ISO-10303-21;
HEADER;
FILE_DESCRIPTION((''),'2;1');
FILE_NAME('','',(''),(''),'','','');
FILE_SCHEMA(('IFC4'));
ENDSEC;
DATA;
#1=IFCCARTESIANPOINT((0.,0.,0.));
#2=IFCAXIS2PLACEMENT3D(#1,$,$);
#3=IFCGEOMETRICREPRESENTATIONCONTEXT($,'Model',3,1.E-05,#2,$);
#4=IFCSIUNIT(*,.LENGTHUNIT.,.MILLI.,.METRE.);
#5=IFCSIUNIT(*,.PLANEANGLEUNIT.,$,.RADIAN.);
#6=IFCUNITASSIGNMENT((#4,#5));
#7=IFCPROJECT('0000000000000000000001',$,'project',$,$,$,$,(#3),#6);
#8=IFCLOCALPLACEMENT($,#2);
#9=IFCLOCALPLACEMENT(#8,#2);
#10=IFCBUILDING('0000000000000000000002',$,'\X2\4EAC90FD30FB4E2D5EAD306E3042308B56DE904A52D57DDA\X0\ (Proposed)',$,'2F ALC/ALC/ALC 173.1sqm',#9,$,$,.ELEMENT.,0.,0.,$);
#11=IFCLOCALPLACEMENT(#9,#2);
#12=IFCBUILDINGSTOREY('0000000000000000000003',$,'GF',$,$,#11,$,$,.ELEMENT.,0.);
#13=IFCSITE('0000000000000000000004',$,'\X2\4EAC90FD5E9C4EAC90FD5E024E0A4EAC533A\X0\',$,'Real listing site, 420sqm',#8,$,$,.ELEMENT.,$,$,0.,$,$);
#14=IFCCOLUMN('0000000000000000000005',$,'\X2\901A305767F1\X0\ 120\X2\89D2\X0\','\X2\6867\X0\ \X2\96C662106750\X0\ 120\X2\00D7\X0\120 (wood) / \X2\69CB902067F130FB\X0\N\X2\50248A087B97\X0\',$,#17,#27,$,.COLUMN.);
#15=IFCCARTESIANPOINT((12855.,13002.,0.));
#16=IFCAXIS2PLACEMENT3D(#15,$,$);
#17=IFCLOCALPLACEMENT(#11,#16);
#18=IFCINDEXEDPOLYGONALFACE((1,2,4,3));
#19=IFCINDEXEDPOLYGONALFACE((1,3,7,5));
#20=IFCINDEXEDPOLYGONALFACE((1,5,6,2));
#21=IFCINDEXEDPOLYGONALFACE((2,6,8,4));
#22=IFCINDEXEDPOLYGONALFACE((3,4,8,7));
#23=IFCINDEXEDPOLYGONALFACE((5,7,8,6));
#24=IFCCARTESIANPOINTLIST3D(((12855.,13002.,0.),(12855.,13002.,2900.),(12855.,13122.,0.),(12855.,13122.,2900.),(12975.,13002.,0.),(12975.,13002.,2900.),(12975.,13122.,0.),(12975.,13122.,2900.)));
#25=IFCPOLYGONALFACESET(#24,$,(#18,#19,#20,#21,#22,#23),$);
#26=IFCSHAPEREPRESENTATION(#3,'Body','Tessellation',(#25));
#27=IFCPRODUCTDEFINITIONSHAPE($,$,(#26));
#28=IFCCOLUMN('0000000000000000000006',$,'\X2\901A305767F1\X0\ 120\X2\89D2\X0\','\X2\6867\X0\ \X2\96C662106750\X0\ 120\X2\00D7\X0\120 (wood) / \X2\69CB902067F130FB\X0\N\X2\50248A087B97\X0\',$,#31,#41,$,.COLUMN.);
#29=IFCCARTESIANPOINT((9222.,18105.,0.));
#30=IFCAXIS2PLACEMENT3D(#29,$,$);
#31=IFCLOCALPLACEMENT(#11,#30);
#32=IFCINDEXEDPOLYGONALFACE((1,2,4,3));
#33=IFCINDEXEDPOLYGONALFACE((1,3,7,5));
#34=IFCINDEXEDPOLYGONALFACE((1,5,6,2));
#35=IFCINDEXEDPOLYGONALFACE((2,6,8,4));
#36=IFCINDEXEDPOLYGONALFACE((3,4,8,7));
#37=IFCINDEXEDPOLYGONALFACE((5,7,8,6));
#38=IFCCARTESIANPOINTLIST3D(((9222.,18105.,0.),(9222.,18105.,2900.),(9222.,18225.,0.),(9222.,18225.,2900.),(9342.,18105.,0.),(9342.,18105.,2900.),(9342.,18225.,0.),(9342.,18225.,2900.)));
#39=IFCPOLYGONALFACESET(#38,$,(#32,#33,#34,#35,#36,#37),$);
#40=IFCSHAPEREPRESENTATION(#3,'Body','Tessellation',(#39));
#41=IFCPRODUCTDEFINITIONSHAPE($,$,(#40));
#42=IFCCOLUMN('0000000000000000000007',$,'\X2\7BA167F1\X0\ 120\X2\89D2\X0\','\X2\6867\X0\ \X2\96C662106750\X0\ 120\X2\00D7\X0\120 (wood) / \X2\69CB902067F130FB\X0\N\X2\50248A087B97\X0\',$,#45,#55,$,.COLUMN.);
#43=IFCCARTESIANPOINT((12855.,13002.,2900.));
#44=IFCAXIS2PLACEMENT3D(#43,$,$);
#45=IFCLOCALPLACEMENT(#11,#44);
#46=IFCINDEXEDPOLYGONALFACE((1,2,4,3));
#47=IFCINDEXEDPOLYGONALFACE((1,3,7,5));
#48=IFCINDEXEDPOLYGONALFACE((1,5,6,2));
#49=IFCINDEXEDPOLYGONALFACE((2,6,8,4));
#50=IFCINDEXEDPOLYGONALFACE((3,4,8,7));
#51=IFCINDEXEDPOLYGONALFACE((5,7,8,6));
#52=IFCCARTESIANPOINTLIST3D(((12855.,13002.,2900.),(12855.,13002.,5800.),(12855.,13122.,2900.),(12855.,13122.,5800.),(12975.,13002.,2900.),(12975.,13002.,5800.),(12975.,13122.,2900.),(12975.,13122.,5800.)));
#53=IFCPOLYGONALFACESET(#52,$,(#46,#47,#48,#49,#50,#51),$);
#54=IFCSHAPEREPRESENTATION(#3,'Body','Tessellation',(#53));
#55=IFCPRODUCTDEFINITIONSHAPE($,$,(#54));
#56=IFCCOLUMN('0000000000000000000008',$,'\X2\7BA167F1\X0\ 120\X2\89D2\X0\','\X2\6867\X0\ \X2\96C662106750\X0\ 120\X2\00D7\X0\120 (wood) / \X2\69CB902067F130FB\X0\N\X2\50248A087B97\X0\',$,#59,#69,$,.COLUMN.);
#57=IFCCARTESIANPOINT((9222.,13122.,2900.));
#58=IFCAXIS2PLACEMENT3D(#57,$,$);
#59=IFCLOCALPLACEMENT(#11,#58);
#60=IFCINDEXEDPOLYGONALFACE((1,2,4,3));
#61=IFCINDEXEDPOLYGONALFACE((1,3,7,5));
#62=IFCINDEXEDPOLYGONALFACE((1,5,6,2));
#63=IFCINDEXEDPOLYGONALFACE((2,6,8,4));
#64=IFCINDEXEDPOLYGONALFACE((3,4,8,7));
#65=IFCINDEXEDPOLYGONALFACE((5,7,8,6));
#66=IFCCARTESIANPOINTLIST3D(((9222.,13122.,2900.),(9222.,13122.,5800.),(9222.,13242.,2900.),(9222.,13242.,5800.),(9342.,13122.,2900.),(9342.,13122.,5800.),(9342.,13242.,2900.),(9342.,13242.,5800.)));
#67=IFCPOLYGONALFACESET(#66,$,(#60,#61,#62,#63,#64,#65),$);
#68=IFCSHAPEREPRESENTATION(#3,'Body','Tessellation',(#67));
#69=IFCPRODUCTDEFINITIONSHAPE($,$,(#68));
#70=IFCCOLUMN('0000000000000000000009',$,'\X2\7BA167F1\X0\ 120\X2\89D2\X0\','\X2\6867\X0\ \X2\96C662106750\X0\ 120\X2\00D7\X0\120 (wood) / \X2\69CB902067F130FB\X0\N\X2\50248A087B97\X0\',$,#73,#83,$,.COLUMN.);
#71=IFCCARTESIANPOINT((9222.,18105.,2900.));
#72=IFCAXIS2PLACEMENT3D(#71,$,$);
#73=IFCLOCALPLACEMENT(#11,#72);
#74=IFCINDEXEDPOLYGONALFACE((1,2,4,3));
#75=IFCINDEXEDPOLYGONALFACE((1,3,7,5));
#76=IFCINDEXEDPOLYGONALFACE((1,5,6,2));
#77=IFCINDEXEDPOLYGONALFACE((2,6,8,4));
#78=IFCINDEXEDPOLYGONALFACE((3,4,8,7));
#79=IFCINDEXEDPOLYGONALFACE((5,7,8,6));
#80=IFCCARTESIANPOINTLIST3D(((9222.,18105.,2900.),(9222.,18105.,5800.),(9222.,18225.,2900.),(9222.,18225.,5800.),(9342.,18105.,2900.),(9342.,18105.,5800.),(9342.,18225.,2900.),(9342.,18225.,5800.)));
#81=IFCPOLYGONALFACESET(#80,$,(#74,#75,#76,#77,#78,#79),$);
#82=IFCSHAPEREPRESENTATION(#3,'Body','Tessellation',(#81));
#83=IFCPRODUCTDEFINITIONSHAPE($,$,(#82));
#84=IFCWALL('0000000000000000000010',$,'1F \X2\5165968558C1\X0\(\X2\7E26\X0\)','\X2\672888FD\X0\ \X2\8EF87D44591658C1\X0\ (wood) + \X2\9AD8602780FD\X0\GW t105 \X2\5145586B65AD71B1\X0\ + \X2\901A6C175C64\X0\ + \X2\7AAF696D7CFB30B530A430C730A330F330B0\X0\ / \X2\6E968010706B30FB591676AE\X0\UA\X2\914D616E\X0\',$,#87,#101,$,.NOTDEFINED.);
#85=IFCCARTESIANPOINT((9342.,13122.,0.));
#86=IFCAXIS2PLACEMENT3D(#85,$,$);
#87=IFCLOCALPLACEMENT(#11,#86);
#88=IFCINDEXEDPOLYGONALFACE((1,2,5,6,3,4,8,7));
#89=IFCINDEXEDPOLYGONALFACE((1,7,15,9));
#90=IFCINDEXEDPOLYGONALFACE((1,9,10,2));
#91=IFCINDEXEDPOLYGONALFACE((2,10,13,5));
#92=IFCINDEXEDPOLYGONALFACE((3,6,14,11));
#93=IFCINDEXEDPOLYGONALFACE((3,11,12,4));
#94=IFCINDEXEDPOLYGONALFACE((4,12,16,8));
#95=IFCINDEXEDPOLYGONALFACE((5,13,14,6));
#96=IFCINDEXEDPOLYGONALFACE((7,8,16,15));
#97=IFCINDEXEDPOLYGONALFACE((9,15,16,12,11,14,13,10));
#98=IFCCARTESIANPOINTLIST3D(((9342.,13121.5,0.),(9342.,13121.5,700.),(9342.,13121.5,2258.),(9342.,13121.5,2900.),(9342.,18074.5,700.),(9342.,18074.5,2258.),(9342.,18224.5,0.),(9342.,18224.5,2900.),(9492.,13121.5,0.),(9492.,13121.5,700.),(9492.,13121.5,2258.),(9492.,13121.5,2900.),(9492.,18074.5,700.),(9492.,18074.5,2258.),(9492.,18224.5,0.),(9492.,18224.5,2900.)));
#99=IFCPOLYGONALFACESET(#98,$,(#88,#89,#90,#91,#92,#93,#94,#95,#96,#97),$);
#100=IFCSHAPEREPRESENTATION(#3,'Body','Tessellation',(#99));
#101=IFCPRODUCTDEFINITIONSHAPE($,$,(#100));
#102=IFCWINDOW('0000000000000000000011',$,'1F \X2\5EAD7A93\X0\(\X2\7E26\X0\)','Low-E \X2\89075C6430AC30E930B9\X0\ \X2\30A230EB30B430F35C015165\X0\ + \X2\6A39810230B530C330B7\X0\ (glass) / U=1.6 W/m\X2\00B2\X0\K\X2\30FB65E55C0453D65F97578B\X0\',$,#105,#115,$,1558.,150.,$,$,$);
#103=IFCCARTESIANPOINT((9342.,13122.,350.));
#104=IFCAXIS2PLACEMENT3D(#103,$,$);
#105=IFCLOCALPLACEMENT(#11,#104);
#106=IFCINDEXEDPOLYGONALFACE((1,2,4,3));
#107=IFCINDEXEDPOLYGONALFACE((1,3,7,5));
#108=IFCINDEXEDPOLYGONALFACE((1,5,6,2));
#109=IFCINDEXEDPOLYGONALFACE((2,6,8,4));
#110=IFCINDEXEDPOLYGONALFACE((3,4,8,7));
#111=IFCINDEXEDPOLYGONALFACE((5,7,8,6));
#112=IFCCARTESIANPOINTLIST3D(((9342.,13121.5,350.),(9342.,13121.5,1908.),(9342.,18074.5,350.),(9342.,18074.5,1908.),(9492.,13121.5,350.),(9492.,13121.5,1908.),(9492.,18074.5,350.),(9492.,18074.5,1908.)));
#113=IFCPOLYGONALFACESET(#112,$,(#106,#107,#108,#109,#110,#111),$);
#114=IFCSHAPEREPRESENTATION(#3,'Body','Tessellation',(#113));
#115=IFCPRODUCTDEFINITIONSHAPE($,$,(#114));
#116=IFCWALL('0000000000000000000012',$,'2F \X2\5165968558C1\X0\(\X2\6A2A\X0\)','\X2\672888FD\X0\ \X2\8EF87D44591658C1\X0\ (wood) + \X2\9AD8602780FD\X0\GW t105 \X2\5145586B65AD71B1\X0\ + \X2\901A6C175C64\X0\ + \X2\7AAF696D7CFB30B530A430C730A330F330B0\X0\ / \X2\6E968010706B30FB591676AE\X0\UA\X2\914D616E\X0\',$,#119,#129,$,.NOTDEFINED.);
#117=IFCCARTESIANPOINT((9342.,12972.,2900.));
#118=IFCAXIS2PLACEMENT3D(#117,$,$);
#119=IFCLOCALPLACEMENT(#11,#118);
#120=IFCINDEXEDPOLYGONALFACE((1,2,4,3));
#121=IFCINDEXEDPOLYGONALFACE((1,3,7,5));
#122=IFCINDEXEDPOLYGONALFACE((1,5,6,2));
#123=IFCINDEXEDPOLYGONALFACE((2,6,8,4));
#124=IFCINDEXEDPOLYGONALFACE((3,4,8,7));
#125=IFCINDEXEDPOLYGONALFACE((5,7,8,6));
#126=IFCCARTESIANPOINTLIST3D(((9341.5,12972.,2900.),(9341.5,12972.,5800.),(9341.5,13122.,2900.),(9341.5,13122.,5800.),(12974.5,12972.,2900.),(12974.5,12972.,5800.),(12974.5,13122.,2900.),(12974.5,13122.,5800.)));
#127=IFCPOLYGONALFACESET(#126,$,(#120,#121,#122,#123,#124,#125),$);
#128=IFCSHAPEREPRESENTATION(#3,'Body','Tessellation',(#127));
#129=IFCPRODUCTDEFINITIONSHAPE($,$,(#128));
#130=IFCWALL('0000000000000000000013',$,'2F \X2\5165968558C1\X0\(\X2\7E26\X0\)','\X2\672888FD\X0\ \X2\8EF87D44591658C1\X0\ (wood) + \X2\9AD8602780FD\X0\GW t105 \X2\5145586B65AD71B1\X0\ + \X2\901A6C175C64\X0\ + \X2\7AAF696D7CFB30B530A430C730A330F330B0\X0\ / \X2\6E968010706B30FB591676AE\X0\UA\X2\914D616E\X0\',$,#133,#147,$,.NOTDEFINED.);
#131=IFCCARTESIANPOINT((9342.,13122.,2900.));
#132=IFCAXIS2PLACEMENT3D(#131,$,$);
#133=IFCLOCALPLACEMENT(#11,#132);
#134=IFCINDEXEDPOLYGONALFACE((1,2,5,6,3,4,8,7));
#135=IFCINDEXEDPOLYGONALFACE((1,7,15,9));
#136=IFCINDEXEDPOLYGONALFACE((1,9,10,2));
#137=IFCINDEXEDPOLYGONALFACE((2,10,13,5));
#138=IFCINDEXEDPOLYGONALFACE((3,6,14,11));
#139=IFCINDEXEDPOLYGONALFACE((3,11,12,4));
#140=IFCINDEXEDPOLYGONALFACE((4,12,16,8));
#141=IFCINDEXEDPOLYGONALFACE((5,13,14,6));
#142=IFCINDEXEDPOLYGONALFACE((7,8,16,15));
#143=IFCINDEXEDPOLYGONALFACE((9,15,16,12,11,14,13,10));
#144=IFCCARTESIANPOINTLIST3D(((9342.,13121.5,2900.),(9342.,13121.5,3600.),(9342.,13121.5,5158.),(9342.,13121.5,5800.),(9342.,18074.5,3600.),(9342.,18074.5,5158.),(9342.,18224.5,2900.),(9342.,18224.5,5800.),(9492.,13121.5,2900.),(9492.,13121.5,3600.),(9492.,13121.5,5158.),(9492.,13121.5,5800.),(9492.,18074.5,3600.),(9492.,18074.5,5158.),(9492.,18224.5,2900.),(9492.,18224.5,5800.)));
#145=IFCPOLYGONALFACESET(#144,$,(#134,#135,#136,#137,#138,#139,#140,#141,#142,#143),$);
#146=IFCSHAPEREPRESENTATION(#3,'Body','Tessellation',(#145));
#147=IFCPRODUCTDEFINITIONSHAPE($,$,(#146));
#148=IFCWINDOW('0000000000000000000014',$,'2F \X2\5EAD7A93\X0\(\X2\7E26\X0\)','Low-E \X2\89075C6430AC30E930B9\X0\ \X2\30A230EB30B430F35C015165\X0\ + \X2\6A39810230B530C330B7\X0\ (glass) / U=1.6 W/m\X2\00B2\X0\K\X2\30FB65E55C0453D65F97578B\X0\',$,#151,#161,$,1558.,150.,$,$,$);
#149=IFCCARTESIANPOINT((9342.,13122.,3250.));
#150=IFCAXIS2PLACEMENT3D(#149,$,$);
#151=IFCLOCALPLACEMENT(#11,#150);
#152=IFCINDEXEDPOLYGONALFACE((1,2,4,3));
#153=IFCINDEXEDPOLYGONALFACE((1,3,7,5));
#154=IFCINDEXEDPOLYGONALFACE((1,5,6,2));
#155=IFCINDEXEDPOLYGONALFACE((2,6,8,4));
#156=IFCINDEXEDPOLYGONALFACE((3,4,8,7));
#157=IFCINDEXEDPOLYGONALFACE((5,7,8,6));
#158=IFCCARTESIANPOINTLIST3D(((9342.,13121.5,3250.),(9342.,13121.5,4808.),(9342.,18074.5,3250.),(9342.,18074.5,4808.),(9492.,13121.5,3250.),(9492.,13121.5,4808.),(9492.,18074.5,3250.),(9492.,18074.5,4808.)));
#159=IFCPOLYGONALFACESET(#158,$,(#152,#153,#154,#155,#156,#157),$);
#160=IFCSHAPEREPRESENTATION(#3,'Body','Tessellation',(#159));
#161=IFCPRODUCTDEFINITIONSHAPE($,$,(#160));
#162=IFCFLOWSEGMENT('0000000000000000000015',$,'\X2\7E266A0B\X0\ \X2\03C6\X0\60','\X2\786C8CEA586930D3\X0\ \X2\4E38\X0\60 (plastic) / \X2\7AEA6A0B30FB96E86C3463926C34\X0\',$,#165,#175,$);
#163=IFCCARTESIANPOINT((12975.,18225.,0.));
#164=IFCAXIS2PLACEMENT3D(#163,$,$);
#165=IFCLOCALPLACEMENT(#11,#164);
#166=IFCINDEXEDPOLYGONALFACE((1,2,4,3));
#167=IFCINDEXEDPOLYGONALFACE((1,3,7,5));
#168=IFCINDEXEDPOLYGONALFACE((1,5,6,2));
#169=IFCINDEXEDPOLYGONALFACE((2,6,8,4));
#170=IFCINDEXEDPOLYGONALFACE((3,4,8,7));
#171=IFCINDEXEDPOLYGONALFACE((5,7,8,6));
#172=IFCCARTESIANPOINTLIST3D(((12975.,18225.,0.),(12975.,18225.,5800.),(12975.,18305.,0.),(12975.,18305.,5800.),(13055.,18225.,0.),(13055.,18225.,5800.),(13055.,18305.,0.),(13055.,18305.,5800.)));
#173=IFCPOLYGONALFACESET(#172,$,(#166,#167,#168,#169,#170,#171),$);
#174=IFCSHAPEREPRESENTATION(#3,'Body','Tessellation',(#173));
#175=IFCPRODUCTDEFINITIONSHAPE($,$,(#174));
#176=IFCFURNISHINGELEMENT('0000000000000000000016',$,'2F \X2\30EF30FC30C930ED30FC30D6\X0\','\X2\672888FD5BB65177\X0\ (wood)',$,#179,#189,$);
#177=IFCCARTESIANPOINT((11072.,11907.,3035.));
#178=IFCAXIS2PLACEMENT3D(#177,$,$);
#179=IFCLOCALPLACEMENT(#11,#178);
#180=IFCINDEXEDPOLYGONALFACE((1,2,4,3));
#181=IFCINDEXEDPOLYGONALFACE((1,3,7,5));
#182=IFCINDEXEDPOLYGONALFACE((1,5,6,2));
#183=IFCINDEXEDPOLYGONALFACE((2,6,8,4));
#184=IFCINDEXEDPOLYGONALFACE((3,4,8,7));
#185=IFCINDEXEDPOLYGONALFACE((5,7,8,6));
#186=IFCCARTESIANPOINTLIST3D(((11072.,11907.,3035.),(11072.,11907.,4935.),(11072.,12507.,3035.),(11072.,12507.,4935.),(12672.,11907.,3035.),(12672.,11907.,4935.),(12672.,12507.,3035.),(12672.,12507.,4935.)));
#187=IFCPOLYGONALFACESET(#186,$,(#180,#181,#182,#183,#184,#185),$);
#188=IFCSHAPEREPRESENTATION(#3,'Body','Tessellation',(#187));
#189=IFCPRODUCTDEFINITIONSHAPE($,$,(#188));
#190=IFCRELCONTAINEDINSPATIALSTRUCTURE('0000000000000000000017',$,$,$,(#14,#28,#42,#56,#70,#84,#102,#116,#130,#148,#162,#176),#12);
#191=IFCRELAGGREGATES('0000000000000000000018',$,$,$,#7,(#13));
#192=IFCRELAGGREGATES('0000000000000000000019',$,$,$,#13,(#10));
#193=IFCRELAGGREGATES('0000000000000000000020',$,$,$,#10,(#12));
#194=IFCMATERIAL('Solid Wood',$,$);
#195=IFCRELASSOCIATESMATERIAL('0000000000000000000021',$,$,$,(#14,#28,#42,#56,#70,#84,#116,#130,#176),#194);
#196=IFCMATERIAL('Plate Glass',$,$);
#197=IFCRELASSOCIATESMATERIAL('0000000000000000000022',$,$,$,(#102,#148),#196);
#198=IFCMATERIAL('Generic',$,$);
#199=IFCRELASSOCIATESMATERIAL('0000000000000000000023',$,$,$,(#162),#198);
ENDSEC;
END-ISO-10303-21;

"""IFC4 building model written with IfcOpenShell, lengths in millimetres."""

from ifc_helpers import new_model, si_unit, frame, frame_2d, origin, place, context, project, spatial, rectangle, extrude, material, element, fill, save


model = new_model("IFC4")

# Units and contexts
model_context = context("Model", 3, precision=1e-05, world=origin())
ifc_project = project(units=[si_unit("LENGTHUNIT", "METRE", prefix="MILLI"), si_unit("PLANEANGLEUNIT", "RADIAN")], contexts=[model_context])

# Site, building, storey
site_placement = place(None, origin())
site = spatial("IfcSite", under=ifc_project, at=site_placement, Name="京都府京都市上京区", ObjectType="Real listing site, 420sqm", CompositionType="ELEMENT", RefElevation=0.0)
building_placement = place(site_placement, origin())
building = spatial("IfcBuilding", under=site, at=building_placement, Name="京都・中庭のある回遊動線 (Proposed)", ObjectType="2F ALC/ALC/ALC 173.1sqm", CompositionType="ELEMENT", ElevationOfRefHeight=0.0, ElevationOfTerrain=0.0)
storey_placement = place(building_placement, origin())
storey = spatial("IfcBuildingStorey", under=building, at=storey_placement, Name="GF", CompositionType="ELEMENT", Elevation=0.0)

# Columns
ifc_material_1 = material(Name="Solid Wood")
column_1_placement = place(storey_placement, frame((12855.0, 13002.0, 0.0)))
element("IfcColumn", 1, at=column_1_placement, inside=storey, material=ifc_material_1, Name="通し柱 120角", Description="桧 集成材 120×120 (wood) / 構造柱・N値計算", PredefinedType="COLUMN", context=model_context, shape_type="SweptSolid", body=[
    extrude(rectangle(XDim=120.0, YDim=120.0, at=frame_2d((60.0, 60.0))), frame((12855.0, 13002.0, 0.0)), (0.0, 0.0, 1.0), 2900.0),
])
column_2_placement = place(storey_placement, frame((9222.0, 18105.0, 0.0)))
element("IfcColumn", 2, at=column_2_placement, inside=storey, material=ifc_material_1, Name="通し柱 120角", Description="桧 集成材 120×120 (wood) / 構造柱・N値計算", PredefinedType="COLUMN", context=model_context, shape_type="SweptSolid", body=[
    extrude(rectangle(XDim=120.0, YDim=120.0, at=frame_2d((60.0, 60.0))), frame((9222.0, 18105.0, 0.0)), (0.0, 0.0, 1.0), 2900.0),
])
column_3_placement = place(storey_placement, frame((12855.0, 13002.0, 2900.0)))
element("IfcColumn", 3, at=column_3_placement, inside=storey, material=ifc_material_1, Name="管柱 120角", Description="桧 集成材 120×120 (wood) / 構造柱・N値計算", PredefinedType="COLUMN", context=model_context, shape_type="SweptSolid", body=[
    extrude(rectangle(XDim=120.0, YDim=120.0, at=frame_2d((60.0, 60.0))), frame((12855.0, 13002.0, 2900.0)), (0.0, 0.0, 1.0), 2900.0),
])
column_4_placement = place(storey_placement, frame((9222.0, 13122.0, 2900.0)))
element("IfcColumn", 4, at=column_4_placement, inside=storey, material=ifc_material_1, Name="管柱 120角", Description="桧 集成材 120×120 (wood) / 構造柱・N値計算", PredefinedType="COLUMN", context=model_context, shape_type="SweptSolid", body=[
    extrude(rectangle(XDim=120.0, YDim=120.0, at=frame_2d((60.0, 60.0))), frame((9222.0, 13122.0, 2900.0)), (0.0, 0.0, 1.0), 2900.0),
])
column_5_placement = place(storey_placement, frame((9222.0, 18105.0, 2900.0)))
element("IfcColumn", 5, at=column_5_placement, inside=storey, material=ifc_material_1, Name="管柱 120角", Description="桧 集成材 120×120 (wood) / 構造柱・N値計算", PredefinedType="COLUMN", context=model_context, shape_type="SweptSolid", body=[
    extrude(rectangle(XDim=120.0, YDim=120.0, at=frame_2d((60.0, 60.0))), frame((9222.0, 18105.0, 2900.0)), (0.0, 0.0, 1.0), 2900.0),
])

# Wall, opening, window
wall_1_placement = place(storey_placement, frame((9342.0, 13122.0, 0.0)))
wall_1 = element("IfcWall", 6, at=wall_1_placement, inside=storey, material=ifc_material_1, Name="1F 入隅壁(縦)", Description="木製 軸組外壁 (wood) + 高性能GW t105 充填断熱 + 通気層 + 窯業系サイディング / 準耐火・外皮UA配慮", PredefinedType="NOTDEFINED", context=model_context, shape_type="SweptSolid", body=[
    extrude(rectangle(XDim=150.0, YDim=5103.0, at=frame_2d((75.0, 2551.0))), frame((9342.0, 13122.0, 0.0)), (0.0, 0.0, 1.0), 2900.0),
])
opening_1_placement = place(storey_placement, frame((9342.0, 13122.0, 350.0)))
opening_1 = element("IfcOpeningElement", 7, at=opening_1_placement, cuts=wall_1, PredefinedType="NOTDEFINED", context=model_context, shape_type="SweptSolid", body=[
    extrude(rectangle(XDim=150.0, YDim=4953.0, at=frame_2d((75.0, 2476.0))), frame((9342.0, 13122.0, 350.0)), (0.0, 0.0, 1.0), 1558.0),
])
ifc_material_2 = material(Name="Plate Glass")
window_1_placement = place(storey_placement, frame((9342.0, 13122.0, 350.0)))
window_1 = element("IfcWindow", 8, at=window_1_placement, inside=storey, material=ifc_material_2, Name="1F 庭窓(縦)", Description="Low-E 複層ガラス アルゴン封入 + 樹脂サッシ (glass) / U=1.6 W/m²K・日射取得型", OverallHeight=1558.0, OverallWidth=150.0, context=model_context, shape_type="SweptSolid", body=[
    extrude(rectangle(XDim=150.0, YDim=4953.0, at=frame_2d((75.0, 2476.0))), frame((9342.0, 13122.0, 350.0)), (0.0, 0.0, 1.0), 1558.0),
])
fill(opening_1, window_1)

# Wall
wall_2_placement = place(storey_placement, frame((9342.0, 12972.0, 2900.0)))
element("IfcWall", 9, at=wall_2_placement, inside=storey, material=ifc_material_1, Name="2F 入隅壁(横)", Description="木製 軸組外壁 (wood) + 高性能GW t105 充填断熱 + 通気層 + 窯業系サイディング / 準耐火・外皮UA配慮", PredefinedType="NOTDEFINED", context=model_context, shape_type="SweptSolid", body=[
    extrude(rectangle(XDim=3633.0, YDim=150.0, at=frame_2d((1816.0, 75.0))), frame((9342.0, 12972.0, 2900.0)), (0.0, 0.0, 1.0), 2900.0),
])

# Wall, opening, window
wall_3_placement = place(storey_placement, frame((9342.0, 13122.0, 2900.0)))
wall_3 = element("IfcWall", 10, at=wall_3_placement, inside=storey, material=ifc_material_1, Name="2F 入隅壁(縦)", Description="木製 軸組外壁 (wood) + 高性能GW t105 充填断熱 + 通気層 + 窯業系サイディング / 準耐火・外皮UA配慮", PredefinedType="NOTDEFINED", context=model_context, shape_type="SweptSolid", body=[
    extrude(rectangle(XDim=150.0, YDim=5103.0, at=frame_2d((75.0, 2551.0))), frame((9342.0, 13122.0, 2900.0)), (0.0, 0.0, 1.0), 2900.0),
])
opening_2_placement = place(storey_placement, frame((9342.0, 13122.0, 3250.0)))
opening_2 = element("IfcOpeningElement", 11, at=opening_2_placement, cuts=wall_3, PredefinedType="NOTDEFINED", context=model_context, shape_type="SweptSolid", body=[
    extrude(rectangle(XDim=150.0, YDim=4953.0, at=frame_2d((75.0, 2476.0))), frame((9342.0, 13122.0, 3250.0)), (0.0, 0.0, 1.0), 1558.0),
])
window_2_placement = place(storey_placement, frame((9342.0, 13122.0, 3250.0)))
window_2 = element("IfcWindow", 12, at=window_2_placement, inside=storey, material=ifc_material_2, Name="2F 庭窓(縦)", Description="Low-E 複層ガラス アルゴン封入 + 樹脂サッシ (glass) / U=1.6 W/m²K・日射取得型", OverallHeight=1558.0, OverallWidth=150.0, context=model_context, shape_type="SweptSolid", body=[
    extrude(rectangle(XDim=150.0, YDim=4953.0, at=frame_2d((75.0, 2476.0))), frame((9342.0, 13122.0, 3250.0)), (0.0, 0.0, 1.0), 1558.0),
])
fill(opening_2, window_2)

# Flow segment
ifc_material_3 = material(Name="Generic")
flow_segment_placement = place(storey_placement, frame((12975.0, 18225.0, 0.0)))
element("IfcFlowSegment", 13, at=flow_segment_placement, inside=storey, material=ifc_material_3, Name="縦樋 φ60", Description="硬質塩ビ 丸60 (plastic) / 竪樋・雨水排水", context=model_context, shape_type="SweptSolid", body=[
    extrude(rectangle(XDim=80.0, YDim=80.0, at=frame_2d((40.0, 40.0))), frame((12975.0, 18225.0, 0.0)), (0.0, 0.0, 1.0), 5800.0),
])

# Furnishing element
furnishing_placement = place(storey_placement, frame((11072.0, 11907.0, 3035.0)))
element("IfcFurnishingElement", 14, at=furnishing_placement, inside=storey, material=ifc_material_1, Name="2F ワードローブ", Description="木製家具 (wood)", context=model_context, shape_type="SweptSolid", body=[
    extrude(rectangle(XDim=1600.0, YDim=600.0, at=frame_2d((800.0, 300.0))), frame((11072.0, 11907.0, 3035.0)), (0.0, 0.0, 1.0), 1900.0),
])

save(model, "model.ifc")
